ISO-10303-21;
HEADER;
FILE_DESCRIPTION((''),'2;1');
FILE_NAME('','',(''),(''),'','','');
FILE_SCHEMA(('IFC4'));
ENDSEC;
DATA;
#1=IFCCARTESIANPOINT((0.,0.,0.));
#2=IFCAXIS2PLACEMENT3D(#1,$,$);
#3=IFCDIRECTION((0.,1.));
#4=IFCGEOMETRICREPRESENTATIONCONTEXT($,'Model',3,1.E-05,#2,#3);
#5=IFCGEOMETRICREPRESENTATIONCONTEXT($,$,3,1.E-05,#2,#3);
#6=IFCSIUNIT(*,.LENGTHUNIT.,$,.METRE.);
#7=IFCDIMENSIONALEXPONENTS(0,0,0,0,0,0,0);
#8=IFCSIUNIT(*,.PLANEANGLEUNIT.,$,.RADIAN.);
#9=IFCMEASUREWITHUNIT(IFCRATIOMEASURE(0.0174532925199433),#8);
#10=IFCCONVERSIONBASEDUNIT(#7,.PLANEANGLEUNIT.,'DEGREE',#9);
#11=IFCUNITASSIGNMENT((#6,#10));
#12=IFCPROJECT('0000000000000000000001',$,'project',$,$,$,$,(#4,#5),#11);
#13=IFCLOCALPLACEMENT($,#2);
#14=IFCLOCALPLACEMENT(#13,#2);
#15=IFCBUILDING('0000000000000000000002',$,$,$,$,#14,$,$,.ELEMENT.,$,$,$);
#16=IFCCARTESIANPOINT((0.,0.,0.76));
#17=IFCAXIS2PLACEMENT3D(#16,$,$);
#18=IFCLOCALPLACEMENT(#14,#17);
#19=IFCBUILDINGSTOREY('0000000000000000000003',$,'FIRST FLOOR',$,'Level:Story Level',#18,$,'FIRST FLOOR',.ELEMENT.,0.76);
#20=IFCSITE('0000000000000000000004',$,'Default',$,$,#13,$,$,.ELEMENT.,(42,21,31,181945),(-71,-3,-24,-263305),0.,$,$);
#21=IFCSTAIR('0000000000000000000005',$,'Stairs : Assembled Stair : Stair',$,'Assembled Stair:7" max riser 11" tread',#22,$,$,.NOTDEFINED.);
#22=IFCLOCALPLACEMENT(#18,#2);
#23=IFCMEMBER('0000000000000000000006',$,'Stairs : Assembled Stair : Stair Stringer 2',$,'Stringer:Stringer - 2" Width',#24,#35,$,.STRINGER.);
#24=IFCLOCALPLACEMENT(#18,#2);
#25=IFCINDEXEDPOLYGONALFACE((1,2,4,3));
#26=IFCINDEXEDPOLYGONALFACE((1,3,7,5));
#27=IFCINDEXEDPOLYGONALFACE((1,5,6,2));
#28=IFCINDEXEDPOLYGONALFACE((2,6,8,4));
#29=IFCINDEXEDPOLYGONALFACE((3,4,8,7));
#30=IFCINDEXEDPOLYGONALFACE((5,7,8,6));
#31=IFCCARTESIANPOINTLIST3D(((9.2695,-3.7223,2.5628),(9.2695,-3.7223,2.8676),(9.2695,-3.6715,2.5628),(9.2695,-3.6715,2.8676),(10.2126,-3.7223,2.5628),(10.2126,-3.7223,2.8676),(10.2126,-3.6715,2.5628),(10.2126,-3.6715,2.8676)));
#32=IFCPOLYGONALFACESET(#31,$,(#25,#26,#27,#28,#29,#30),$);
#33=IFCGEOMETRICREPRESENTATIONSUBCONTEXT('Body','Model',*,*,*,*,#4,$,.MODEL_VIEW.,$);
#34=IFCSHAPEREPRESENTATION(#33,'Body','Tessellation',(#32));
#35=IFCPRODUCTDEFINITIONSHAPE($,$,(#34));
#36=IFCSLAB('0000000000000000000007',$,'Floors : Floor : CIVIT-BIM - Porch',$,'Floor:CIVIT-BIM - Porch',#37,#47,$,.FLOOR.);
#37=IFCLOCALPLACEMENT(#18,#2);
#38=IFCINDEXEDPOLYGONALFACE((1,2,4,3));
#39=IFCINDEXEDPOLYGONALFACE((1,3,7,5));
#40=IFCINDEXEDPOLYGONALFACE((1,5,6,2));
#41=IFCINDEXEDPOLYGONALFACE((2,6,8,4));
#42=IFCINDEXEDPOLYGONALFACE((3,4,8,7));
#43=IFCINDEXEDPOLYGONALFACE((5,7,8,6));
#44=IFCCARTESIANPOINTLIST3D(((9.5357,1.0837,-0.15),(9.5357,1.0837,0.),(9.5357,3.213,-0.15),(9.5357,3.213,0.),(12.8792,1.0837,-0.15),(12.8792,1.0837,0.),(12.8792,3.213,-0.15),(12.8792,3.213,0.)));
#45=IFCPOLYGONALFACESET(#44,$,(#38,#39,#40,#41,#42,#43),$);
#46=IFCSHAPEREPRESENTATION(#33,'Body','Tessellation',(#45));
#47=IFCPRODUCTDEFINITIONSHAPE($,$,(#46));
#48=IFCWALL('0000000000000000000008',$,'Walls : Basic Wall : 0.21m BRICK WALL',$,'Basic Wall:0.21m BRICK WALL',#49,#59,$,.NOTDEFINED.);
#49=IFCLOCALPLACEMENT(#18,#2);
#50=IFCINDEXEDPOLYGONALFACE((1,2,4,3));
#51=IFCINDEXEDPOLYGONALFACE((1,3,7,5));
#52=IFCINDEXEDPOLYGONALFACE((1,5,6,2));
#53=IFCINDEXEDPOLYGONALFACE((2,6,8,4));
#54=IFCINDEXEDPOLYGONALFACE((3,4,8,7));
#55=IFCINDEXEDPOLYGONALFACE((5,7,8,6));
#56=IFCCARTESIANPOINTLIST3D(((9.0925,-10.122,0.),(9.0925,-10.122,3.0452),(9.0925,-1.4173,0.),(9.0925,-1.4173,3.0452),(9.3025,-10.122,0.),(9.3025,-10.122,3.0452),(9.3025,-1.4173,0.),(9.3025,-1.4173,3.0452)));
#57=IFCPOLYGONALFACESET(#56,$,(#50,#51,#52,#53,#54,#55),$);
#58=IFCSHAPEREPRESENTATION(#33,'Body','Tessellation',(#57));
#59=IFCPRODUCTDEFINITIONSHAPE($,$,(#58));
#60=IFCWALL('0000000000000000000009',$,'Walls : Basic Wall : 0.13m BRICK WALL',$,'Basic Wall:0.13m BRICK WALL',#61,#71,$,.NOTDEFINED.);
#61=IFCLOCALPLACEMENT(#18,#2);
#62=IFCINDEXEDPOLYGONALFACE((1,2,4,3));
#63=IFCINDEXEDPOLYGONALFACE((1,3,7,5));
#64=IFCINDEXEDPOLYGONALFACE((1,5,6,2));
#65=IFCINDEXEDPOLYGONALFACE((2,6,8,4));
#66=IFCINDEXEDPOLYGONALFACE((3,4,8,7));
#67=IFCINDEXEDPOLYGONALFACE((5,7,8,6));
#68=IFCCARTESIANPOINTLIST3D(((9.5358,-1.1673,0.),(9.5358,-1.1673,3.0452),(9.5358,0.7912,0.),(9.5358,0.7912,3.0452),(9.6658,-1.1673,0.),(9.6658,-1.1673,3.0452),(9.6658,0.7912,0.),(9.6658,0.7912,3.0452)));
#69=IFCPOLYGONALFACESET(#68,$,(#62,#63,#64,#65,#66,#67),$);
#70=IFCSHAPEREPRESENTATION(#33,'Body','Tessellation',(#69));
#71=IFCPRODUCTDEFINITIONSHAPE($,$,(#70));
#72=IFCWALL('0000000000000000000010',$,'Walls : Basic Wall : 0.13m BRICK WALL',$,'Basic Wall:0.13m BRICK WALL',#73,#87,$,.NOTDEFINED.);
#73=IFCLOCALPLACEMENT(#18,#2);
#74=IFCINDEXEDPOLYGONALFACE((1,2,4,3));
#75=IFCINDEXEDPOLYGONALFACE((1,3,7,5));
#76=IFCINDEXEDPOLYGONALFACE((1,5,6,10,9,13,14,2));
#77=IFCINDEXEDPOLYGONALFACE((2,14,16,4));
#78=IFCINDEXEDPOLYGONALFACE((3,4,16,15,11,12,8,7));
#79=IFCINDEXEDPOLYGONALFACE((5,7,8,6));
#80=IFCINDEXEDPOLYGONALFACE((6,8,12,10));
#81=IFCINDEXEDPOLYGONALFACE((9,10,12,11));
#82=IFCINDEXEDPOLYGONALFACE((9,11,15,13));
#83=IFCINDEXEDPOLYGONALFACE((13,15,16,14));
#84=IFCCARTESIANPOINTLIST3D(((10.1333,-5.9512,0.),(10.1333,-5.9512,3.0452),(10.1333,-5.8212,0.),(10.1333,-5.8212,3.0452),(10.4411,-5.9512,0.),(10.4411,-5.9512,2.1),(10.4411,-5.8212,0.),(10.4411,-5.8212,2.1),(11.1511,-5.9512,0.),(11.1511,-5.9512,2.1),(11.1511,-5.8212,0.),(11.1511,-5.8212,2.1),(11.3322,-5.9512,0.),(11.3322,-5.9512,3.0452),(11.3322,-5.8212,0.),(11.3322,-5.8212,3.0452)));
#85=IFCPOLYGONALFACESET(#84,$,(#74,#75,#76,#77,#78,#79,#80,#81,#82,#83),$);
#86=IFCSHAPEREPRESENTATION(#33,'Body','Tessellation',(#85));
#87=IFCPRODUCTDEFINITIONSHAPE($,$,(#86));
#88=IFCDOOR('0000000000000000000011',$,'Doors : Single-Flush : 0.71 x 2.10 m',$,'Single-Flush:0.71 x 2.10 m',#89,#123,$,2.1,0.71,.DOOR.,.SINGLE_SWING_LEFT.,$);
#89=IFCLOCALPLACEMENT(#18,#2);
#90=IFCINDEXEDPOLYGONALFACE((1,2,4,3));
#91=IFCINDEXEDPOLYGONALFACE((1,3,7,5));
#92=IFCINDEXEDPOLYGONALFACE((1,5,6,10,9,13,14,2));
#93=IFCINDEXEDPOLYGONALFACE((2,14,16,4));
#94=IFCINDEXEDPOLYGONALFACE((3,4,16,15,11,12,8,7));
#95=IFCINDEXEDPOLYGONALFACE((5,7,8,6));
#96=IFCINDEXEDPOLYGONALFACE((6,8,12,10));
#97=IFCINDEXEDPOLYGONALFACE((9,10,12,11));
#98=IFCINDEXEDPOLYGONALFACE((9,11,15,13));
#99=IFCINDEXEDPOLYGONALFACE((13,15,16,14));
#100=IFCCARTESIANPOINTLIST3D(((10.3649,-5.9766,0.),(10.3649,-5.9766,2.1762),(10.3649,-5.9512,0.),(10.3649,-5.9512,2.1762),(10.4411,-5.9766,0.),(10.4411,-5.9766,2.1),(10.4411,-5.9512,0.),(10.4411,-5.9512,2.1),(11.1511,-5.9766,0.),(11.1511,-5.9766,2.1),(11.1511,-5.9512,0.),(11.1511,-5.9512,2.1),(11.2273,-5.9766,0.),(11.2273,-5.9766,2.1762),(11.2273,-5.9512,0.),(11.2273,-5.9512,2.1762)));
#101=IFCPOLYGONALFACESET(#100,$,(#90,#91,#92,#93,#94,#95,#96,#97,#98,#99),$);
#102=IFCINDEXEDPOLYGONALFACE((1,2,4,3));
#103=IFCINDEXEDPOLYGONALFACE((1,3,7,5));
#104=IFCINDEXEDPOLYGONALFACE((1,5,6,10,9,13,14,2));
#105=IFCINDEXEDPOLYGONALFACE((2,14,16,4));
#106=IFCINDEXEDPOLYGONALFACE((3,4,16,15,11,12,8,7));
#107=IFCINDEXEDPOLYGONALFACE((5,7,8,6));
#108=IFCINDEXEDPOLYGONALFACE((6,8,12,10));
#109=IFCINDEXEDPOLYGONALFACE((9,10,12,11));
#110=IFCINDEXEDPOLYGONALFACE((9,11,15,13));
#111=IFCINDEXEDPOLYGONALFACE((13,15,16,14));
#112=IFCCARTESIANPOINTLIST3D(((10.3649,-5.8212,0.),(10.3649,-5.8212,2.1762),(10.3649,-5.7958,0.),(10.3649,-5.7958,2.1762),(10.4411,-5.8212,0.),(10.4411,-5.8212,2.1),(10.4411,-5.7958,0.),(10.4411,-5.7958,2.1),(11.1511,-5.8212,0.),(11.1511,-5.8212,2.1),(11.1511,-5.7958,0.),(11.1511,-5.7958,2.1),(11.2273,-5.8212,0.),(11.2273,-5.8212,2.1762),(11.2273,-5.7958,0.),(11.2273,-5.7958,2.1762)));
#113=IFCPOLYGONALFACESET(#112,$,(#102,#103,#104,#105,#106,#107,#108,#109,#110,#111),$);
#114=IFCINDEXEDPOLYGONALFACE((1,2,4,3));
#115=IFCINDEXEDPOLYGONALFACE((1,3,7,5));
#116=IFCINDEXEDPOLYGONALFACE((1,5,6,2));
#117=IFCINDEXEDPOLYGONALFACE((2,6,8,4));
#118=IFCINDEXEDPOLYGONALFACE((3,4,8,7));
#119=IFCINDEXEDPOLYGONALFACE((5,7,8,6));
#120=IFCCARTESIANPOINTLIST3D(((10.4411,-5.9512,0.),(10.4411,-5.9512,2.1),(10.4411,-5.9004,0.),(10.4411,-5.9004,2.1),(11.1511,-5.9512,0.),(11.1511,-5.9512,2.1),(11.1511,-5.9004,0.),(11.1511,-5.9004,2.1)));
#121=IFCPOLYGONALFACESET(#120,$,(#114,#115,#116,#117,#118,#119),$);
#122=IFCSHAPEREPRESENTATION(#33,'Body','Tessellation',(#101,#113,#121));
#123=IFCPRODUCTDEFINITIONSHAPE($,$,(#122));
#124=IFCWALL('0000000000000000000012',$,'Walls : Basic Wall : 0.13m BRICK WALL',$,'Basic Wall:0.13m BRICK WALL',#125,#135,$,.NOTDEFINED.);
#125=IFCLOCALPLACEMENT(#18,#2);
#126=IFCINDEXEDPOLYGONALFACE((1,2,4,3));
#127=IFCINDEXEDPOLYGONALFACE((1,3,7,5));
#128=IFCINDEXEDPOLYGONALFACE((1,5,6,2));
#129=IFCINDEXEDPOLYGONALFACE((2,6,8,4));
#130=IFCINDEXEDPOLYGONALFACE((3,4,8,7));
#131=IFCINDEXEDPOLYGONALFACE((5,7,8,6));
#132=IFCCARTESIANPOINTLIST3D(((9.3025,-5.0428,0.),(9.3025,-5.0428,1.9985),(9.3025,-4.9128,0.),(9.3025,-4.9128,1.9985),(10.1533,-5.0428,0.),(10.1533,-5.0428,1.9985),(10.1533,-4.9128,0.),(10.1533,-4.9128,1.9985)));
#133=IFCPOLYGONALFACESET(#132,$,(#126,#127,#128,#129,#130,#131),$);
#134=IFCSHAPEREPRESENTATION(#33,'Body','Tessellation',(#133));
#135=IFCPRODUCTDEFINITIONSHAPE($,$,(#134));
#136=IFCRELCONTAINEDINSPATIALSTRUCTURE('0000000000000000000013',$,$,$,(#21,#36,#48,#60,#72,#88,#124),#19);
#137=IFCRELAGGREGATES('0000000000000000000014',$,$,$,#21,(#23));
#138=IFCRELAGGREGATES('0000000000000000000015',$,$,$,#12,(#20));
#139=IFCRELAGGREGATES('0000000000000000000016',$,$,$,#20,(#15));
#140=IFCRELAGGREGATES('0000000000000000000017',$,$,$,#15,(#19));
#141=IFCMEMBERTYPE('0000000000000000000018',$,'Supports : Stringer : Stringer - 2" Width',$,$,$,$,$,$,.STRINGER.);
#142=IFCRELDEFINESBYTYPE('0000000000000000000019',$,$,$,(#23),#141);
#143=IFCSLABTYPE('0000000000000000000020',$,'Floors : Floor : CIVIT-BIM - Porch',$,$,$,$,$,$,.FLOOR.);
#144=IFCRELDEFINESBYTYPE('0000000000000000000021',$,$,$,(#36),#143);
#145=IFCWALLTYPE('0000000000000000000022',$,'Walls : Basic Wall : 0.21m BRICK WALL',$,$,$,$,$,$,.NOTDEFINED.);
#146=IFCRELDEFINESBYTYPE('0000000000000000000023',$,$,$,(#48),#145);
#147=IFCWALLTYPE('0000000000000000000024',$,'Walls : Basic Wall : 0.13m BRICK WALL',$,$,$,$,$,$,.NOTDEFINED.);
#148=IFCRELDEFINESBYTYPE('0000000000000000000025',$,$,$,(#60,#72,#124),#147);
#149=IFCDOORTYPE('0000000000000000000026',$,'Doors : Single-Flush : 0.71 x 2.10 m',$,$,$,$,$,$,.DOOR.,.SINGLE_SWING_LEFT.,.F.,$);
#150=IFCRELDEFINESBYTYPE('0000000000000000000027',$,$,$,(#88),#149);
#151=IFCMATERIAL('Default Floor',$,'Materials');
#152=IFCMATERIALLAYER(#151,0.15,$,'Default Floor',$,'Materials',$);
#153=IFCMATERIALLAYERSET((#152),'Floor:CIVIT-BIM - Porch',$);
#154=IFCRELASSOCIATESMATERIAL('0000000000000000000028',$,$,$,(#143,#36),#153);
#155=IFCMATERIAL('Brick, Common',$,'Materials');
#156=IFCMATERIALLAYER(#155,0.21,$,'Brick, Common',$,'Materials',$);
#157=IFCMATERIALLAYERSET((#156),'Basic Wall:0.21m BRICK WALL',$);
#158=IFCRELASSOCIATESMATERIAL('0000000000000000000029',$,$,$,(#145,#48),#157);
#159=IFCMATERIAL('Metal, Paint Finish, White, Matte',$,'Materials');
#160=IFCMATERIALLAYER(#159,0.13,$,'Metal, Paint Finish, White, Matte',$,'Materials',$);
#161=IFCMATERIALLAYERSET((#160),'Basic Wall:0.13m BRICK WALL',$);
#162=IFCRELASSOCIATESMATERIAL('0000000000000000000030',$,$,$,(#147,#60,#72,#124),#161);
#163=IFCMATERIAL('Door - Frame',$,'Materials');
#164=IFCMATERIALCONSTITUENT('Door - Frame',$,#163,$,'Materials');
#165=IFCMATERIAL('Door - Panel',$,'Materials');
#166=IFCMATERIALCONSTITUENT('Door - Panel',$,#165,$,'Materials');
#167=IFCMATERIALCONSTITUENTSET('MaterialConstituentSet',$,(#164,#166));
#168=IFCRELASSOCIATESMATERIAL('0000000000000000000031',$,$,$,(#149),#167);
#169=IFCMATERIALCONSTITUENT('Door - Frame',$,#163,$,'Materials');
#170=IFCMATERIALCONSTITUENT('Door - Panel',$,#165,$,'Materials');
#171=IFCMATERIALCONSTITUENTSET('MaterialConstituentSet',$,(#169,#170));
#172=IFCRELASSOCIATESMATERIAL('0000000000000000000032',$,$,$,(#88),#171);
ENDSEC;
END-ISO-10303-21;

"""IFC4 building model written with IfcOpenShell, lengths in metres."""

from ifc_helpers import new_model, entity, si_unit, converted_unit, direction, frame, frame_2d, origin, place, context, subcontext, project, spatial, polyline, rectangle, outline, extrude, source, transform, mapped, material, layer, layer_set, layer_usage, constituent, constituent_set, type_object, type_shapes, element, fill, aggregate, save


model = new_model("IFC4")

# Units and contexts
model_context = context("Model", 3, precision=1e-05, world=origin(), true_north=direction((0.0, 1.0)))
context_of_model = context(None, 3, precision=1e-05, world=origin(), true_north=direction((0.0, 1.0)))
body_context = subcontext(model_context, "Body", "Model", "MODEL_VIEW")
ifc_project = project(units=[si_unit("LENGTHUNIT", "METRE"), converted_unit("PLANEANGLEUNIT", "DEGREE", entity("IfcRatioMeasure", 0.0174532925199433), si_unit("PLANEANGLEUNIT", "RADIAN"), dimensions=[0, 0, 0, 0, 0, 0, 0])], contexts=[model_context, context_of_model])

# Site, building, storey
site_placement = place(None, origin())
site = spatial("IfcSite", under=ifc_project, at=site_placement, Name="Default", CompositionType="ELEMENT", RefLatitude=(42, 21, 31, 181945), RefLongitude=(-71, -3, -24, -263305), RefElevation=0.0)
building_placement = place(site_placement, origin())
building = spatial("IfcBuilding", under=site, at=building_placement, CompositionType="ELEMENT")
storey_placement = place(building_placement, frame((0.0, 0.0, 0.76)))
storey = spatial("IfcBuildingStorey", under=building, at=storey_placement, Name="FIRST FLOOR", ObjectType="Level:Story Level", LongName="FIRST FLOOR", CompositionType="ELEMENT", Elevation=0.76)

# Stair, member
stair_placement = place(storey_placement, origin())
stair = element("IfcStair", 1, at=stair_placement, inside=storey, Name="Stairs : Assembled Stair : Stair", ObjectType="Assembled Stair:7\" max riser 11\" tread", PredefinedType="NOTDEFINED")
member_type = type_object("IfcMemberType", Name="Supports : Stringer : Stringer - 2\" Width", PredefinedType="STRINGER")
member_placement = place(stair_placement, frame((9.2695, -3.7223, 2.5628)))
member = element("IfcMember", 2, at=member_placement, type_object=member_type, Name="Stairs : Assembled Stair : Stair Stringer 2", ObjectType="Stringer:Stringer - 2\" Width", PredefinedType="STRINGER", context=body_context, shape_type="SweptSolid", body=[
    extrude(rectangle(XDim=0.9431, YDim=0.0508, at=frame_2d((0.0, 0.0), x_axis=(1.0, 0.0))), frame((0.4715, 0.0254, 0.0)), (0.0, 0.0, 1.0), 0.3048),
])
aggregate(stair, [member])

# Slab
ifc_material_1 = material(Name="Default Floor", Category="Materials")
ifc_layer_1 = layer(ifc_material_1, 0.15, Name="Default Floor", Category="Materials")
ifc_layer_set_1 = layer_set([ifc_layer_1], Name="Floor:CIVIT-BIM - Porch")
ifc_layer_usage_1 = layer_usage(ifc_layer_set_1, "AXIS3", "POSITIVE", 0.0)
slab_type_1 = type_object("IfcSlabType", Name="Floors : Floor : CIVIT-BIM - Porch", PredefinedType="FLOOR", material=ifc_layer_set_1)
slab_1_placement = place(storey_placement, origin())
element("IfcSlab", 3, at=slab_1_placement, inside=storey, type_object=slab_type_1, material=ifc_layer_usage_1, Name="Floors : Floor : CIVIT-BIM - Porch", ObjectType="Floor:CIVIT-BIM - Porch", PredefinedType="FLOOR", context=body_context, shape_type="SweptSolid", body=[
    extrude(rectangle(XDim=2.1293, YDim=3.3435, at=frame_2d((0.0, 0.0), x_axis=(1.0, 0.0))), frame((11.2075, 2.1484, 0.0), z_axis=(0.0, 0.0, -1.0), x_axis=(0.0, 1.0, 0.0)), (0.0, 0.0, 1.0), 0.15),
])

# Walls
ifc_material_2 = material(Name="Brick, Common", Category="Materials")
ifc_layer_2 = layer(ifc_material_2, 0.21, Name="Brick, Common", Category="Materials")
ifc_layer_set_2 = layer_set([ifc_layer_2], Name="Basic Wall:0.21m BRICK WALL")
ifc_layer_usage_2 = layer_usage(ifc_layer_set_2, "AXIS2", "NEGATIVE", 0.105)
wall_type_1 = type_object("IfcWallType", Name="Walls : Basic Wall : 0.21m BRICK WALL", PredefinedType="NOTDEFINED", material=ifc_layer_set_2)
wall_1_placement = place(storey_placement, frame((9.1975, -1.4173, 0.0), z_axis=(0.0, 0.0, 1.0), x_axis=(0.0, -1.0, 0.0)))
element("IfcWall", 4, at=wall_1_placement, inside=storey, type_object=wall_type_1, material=ifc_layer_usage_2, Name="Walls : Basic Wall : 0.21m BRICK WALL", ObjectType="Basic Wall:0.21m BRICK WALL", PredefinedType="NOTDEFINED", context=body_context, shape_type="SweptSolid", body=[
    extrude(rectangle(XDim=8.7047, YDim=0.21, at=frame_2d((4.3524, 0.0), x_axis=(-1.0, 0.0))), origin(), (0.0, 0.0, 1.0), 3.0452),
])
ifc_material_3 = material(Name="Metal, Paint Finish, White, Matte", Category="Materials")
ifc_layer_3 = layer(ifc_material_3, 0.13, Name="Metal, Paint Finish, White, Matte", Category="Materials")
ifc_layer_set_3 = layer_set([ifc_layer_3], Name="Basic Wall:0.13m BRICK WALL")
ifc_layer_usage_3 = layer_usage(ifc_layer_set_3, "AXIS2", "NEGATIVE", 0.065)
wall_type_2 = type_object("IfcWallType", Name="Walls : Basic Wall : 0.13m BRICK WALL", PredefinedType="NOTDEFINED", material=ifc_layer_set_3)
wall_2_placement = place(storey_placement, frame((9.6008, -1.1673, 0.0), z_axis=(0.0, 0.0, 1.0), x_axis=(0.0, 1.0, 0.0)))
element("IfcWall", 5, at=wall_2_placement, inside=storey, type_object=wall_type_2, material=ifc_layer_usage_3, Name="Walls : Basic Wall : 0.13m BRICK WALL", ObjectType="Basic Wall:0.13m BRICK WALL", PredefinedType="NOTDEFINED", context=body_context, shape_type="SweptSolid", body=[
    extrude(rectangle(XDim=1.9585, YDim=0.13, at=frame_2d((0.9793, 0.0), x_axis=(-1.0, 0.0))), origin(), (0.0, 0.0, 1.0), 3.0452),
])

# Shared definitions
ifc_material_4 = material(Name="Door - Frame", Category="Materials")
ifc_material_5 = material(Name="Door - Panel", Category="Materials")

# Wall, opening, door
ifc_layer_usage_4 = layer_usage(ifc_layer_set_3, "AXIS2", "NEGATIVE", 0.065)
wall_3_placement = place(storey_placement, frame((11.3322, -5.8862, 0.0), z_axis=(0.0, 0.0, 1.0), x_axis=(-1.0, 0.0, 0.0)))
wall_3 = element("IfcWall", 6, at=wall_3_placement, inside=storey, type_object=wall_type_2, material=ifc_layer_usage_4, Name="Walls : Basic Wall : 0.13m BRICK WALL", ObjectType="Basic Wall:0.13m BRICK WALL", PredefinedType="NOTDEFINED", context=body_context, shape_type="SweptSolid", body=[
    extrude(rectangle(XDim=1.1989, YDim=0.13, at=frame_2d((0.5995, 0.0), x_axis=(-1.0, 0.0))), origin(), (0.0, 0.0, 1.0), 3.0452),
])
opening_1_placement = place(wall_3_placement, frame((0.1811, -0.065, 0.0)))
opening_1 = element("IfcOpeningElement", 7, at=opening_1_placement, cuts=wall_3, ObjectType="Opening", PredefinedType="OPENING", context=body_context, shape_type="SweptSolid", body=[
    extrude(rectangle(XDim=0.71, YDim=2.1, at=frame_2d((1.05, 0.355), x_axis=(0.0, -1.0))), frame((0.0, 0.0, 0.0), z_axis=(0.0, 1.0, 0.0), x_axis=(0.0, 0.0, 1.0)), (0.0, 0.0, 1.0), 0.13),
])
ifc_constituent_1 = constituent(ifc_material_4, Name="Door - Frame", Category="Materials")
ifc_constituent_2 = constituent(ifc_material_5, Name="Door - Panel", Category="Materials")
ifc_constituent_set_1 = constituent_set(constituents=[ifc_constituent_1, ifc_constituent_2], Name="MaterialConstituentSet")
ifc_constituent_3 = constituent(ifc_material_4, Name="Door - Frame", Category="Materials")
ifc_constituent_4 = constituent(ifc_material_5, Name="Door - Panel", Category="Materials")
ifc_constituent_set_2 = constituent_set(constituents=[ifc_constituent_3, ifc_constituent_4], Name="MaterialConstituentSet")
door_type_1 = type_object("IfcDoorType", Name="Doors : Single-Flush : 0.71 x 2.10 m", OperationType="SINGLE_SWING_LEFT", ParameterTakesPrecedence=False, PredefinedType="DOOR", material=ifc_constituent_set_2)
shared_shape_1 = source(origin(), body_context, "Body", "SweptSolid", [
    extrude(outline(polyline([(-0.4312, -1.1072), (0.4312, -1.1072), (0.4312, 1.0691), (0.355, 1.0691), (0.355, -1.031), (-0.355, -1.031), (-0.355, 1.0691), (-0.4312, 1.0691), (-0.4312, -1.1072)])), frame((0.355, 0.1554, 1.0691), z_axis=(0.0, -1.0, 0.0), x_axis=(-1.0, 0.0, 0.0)), (0.0, 0.0, 1.0), 0.0254),
    extrude(outline(polyline([(-1.1072, -0.4312), (1.0691, -0.4312), (1.0691, -0.355), (-1.031, -0.355), (-1.031, 0.355), (1.0691, 0.355), (1.0691, 0.4312), (-1.1072, 0.4312), (-1.1072, -0.4312)])), frame((0.355, 0.0, 1.0691), z_axis=(0.0, -1.0, 0.0), x_axis=(0.0, 0.0, -1.0)), (0.0, 0.0, 1.0), 0.0254),
    extrude(rectangle(XDim=0.71, YDim=0.0508, at=frame_2d((0.0, 0.0), x_axis=(1.0, 0.0))), frame((0.355, 0.1046, 0.0)), (0.0, 0.0, 1.0), 2.1),
])
type_shapes(door_type_1, [shared_shape_1])
door_1_placement = place(opening_1_placement, origin())
door_1 = element("IfcDoor", 8, at=door_1_placement, inside=storey, type_object=door_type_1, material=ifc_constituent_set_1, Name="Doors : Single-Flush : 0.71 x 2.10 m", ObjectType="Single-Flush:0.71 x 2.10 m", OperationType="SINGLE_SWING_LEFT", OverallHeight=2.1, OverallWidth=0.71, PredefinedType="DOOR", context=body_context, shape_type="MappedRepresentation", body=[
    mapped(shared_shape_1, transform((0.0, 0.0, 0.0), scale=1.0)),
])
fill(opening_1, door_1)

# Wall
ifc_layer_usage_5 = layer_usage(ifc_layer_set_3, "AXIS2", "NEGATIVE", 0.065)
wall_4_placement = place(storey_placement, frame((9.3025, -4.9778, 0.0)))
element("IfcWall", 9, at=wall_4_placement, inside=storey, type_object=wall_type_2, material=ifc_layer_usage_5, Name="Walls : Basic Wall : 0.13m BRICK WALL", ObjectType="Basic Wall:0.13m BRICK WALL", PredefinedType="NOTDEFINED", context=body_context, shape_type="SweptSolid", body=[
    extrude(rectangle(XDim=0.8507, YDim=0.13, at=frame_2d((0.4254, 0.0), x_axis=(-1.0, 0.0))), origin(), (0.0, 0.0, 1.0), 1.9985),
])

save(model, "model.ifc")
